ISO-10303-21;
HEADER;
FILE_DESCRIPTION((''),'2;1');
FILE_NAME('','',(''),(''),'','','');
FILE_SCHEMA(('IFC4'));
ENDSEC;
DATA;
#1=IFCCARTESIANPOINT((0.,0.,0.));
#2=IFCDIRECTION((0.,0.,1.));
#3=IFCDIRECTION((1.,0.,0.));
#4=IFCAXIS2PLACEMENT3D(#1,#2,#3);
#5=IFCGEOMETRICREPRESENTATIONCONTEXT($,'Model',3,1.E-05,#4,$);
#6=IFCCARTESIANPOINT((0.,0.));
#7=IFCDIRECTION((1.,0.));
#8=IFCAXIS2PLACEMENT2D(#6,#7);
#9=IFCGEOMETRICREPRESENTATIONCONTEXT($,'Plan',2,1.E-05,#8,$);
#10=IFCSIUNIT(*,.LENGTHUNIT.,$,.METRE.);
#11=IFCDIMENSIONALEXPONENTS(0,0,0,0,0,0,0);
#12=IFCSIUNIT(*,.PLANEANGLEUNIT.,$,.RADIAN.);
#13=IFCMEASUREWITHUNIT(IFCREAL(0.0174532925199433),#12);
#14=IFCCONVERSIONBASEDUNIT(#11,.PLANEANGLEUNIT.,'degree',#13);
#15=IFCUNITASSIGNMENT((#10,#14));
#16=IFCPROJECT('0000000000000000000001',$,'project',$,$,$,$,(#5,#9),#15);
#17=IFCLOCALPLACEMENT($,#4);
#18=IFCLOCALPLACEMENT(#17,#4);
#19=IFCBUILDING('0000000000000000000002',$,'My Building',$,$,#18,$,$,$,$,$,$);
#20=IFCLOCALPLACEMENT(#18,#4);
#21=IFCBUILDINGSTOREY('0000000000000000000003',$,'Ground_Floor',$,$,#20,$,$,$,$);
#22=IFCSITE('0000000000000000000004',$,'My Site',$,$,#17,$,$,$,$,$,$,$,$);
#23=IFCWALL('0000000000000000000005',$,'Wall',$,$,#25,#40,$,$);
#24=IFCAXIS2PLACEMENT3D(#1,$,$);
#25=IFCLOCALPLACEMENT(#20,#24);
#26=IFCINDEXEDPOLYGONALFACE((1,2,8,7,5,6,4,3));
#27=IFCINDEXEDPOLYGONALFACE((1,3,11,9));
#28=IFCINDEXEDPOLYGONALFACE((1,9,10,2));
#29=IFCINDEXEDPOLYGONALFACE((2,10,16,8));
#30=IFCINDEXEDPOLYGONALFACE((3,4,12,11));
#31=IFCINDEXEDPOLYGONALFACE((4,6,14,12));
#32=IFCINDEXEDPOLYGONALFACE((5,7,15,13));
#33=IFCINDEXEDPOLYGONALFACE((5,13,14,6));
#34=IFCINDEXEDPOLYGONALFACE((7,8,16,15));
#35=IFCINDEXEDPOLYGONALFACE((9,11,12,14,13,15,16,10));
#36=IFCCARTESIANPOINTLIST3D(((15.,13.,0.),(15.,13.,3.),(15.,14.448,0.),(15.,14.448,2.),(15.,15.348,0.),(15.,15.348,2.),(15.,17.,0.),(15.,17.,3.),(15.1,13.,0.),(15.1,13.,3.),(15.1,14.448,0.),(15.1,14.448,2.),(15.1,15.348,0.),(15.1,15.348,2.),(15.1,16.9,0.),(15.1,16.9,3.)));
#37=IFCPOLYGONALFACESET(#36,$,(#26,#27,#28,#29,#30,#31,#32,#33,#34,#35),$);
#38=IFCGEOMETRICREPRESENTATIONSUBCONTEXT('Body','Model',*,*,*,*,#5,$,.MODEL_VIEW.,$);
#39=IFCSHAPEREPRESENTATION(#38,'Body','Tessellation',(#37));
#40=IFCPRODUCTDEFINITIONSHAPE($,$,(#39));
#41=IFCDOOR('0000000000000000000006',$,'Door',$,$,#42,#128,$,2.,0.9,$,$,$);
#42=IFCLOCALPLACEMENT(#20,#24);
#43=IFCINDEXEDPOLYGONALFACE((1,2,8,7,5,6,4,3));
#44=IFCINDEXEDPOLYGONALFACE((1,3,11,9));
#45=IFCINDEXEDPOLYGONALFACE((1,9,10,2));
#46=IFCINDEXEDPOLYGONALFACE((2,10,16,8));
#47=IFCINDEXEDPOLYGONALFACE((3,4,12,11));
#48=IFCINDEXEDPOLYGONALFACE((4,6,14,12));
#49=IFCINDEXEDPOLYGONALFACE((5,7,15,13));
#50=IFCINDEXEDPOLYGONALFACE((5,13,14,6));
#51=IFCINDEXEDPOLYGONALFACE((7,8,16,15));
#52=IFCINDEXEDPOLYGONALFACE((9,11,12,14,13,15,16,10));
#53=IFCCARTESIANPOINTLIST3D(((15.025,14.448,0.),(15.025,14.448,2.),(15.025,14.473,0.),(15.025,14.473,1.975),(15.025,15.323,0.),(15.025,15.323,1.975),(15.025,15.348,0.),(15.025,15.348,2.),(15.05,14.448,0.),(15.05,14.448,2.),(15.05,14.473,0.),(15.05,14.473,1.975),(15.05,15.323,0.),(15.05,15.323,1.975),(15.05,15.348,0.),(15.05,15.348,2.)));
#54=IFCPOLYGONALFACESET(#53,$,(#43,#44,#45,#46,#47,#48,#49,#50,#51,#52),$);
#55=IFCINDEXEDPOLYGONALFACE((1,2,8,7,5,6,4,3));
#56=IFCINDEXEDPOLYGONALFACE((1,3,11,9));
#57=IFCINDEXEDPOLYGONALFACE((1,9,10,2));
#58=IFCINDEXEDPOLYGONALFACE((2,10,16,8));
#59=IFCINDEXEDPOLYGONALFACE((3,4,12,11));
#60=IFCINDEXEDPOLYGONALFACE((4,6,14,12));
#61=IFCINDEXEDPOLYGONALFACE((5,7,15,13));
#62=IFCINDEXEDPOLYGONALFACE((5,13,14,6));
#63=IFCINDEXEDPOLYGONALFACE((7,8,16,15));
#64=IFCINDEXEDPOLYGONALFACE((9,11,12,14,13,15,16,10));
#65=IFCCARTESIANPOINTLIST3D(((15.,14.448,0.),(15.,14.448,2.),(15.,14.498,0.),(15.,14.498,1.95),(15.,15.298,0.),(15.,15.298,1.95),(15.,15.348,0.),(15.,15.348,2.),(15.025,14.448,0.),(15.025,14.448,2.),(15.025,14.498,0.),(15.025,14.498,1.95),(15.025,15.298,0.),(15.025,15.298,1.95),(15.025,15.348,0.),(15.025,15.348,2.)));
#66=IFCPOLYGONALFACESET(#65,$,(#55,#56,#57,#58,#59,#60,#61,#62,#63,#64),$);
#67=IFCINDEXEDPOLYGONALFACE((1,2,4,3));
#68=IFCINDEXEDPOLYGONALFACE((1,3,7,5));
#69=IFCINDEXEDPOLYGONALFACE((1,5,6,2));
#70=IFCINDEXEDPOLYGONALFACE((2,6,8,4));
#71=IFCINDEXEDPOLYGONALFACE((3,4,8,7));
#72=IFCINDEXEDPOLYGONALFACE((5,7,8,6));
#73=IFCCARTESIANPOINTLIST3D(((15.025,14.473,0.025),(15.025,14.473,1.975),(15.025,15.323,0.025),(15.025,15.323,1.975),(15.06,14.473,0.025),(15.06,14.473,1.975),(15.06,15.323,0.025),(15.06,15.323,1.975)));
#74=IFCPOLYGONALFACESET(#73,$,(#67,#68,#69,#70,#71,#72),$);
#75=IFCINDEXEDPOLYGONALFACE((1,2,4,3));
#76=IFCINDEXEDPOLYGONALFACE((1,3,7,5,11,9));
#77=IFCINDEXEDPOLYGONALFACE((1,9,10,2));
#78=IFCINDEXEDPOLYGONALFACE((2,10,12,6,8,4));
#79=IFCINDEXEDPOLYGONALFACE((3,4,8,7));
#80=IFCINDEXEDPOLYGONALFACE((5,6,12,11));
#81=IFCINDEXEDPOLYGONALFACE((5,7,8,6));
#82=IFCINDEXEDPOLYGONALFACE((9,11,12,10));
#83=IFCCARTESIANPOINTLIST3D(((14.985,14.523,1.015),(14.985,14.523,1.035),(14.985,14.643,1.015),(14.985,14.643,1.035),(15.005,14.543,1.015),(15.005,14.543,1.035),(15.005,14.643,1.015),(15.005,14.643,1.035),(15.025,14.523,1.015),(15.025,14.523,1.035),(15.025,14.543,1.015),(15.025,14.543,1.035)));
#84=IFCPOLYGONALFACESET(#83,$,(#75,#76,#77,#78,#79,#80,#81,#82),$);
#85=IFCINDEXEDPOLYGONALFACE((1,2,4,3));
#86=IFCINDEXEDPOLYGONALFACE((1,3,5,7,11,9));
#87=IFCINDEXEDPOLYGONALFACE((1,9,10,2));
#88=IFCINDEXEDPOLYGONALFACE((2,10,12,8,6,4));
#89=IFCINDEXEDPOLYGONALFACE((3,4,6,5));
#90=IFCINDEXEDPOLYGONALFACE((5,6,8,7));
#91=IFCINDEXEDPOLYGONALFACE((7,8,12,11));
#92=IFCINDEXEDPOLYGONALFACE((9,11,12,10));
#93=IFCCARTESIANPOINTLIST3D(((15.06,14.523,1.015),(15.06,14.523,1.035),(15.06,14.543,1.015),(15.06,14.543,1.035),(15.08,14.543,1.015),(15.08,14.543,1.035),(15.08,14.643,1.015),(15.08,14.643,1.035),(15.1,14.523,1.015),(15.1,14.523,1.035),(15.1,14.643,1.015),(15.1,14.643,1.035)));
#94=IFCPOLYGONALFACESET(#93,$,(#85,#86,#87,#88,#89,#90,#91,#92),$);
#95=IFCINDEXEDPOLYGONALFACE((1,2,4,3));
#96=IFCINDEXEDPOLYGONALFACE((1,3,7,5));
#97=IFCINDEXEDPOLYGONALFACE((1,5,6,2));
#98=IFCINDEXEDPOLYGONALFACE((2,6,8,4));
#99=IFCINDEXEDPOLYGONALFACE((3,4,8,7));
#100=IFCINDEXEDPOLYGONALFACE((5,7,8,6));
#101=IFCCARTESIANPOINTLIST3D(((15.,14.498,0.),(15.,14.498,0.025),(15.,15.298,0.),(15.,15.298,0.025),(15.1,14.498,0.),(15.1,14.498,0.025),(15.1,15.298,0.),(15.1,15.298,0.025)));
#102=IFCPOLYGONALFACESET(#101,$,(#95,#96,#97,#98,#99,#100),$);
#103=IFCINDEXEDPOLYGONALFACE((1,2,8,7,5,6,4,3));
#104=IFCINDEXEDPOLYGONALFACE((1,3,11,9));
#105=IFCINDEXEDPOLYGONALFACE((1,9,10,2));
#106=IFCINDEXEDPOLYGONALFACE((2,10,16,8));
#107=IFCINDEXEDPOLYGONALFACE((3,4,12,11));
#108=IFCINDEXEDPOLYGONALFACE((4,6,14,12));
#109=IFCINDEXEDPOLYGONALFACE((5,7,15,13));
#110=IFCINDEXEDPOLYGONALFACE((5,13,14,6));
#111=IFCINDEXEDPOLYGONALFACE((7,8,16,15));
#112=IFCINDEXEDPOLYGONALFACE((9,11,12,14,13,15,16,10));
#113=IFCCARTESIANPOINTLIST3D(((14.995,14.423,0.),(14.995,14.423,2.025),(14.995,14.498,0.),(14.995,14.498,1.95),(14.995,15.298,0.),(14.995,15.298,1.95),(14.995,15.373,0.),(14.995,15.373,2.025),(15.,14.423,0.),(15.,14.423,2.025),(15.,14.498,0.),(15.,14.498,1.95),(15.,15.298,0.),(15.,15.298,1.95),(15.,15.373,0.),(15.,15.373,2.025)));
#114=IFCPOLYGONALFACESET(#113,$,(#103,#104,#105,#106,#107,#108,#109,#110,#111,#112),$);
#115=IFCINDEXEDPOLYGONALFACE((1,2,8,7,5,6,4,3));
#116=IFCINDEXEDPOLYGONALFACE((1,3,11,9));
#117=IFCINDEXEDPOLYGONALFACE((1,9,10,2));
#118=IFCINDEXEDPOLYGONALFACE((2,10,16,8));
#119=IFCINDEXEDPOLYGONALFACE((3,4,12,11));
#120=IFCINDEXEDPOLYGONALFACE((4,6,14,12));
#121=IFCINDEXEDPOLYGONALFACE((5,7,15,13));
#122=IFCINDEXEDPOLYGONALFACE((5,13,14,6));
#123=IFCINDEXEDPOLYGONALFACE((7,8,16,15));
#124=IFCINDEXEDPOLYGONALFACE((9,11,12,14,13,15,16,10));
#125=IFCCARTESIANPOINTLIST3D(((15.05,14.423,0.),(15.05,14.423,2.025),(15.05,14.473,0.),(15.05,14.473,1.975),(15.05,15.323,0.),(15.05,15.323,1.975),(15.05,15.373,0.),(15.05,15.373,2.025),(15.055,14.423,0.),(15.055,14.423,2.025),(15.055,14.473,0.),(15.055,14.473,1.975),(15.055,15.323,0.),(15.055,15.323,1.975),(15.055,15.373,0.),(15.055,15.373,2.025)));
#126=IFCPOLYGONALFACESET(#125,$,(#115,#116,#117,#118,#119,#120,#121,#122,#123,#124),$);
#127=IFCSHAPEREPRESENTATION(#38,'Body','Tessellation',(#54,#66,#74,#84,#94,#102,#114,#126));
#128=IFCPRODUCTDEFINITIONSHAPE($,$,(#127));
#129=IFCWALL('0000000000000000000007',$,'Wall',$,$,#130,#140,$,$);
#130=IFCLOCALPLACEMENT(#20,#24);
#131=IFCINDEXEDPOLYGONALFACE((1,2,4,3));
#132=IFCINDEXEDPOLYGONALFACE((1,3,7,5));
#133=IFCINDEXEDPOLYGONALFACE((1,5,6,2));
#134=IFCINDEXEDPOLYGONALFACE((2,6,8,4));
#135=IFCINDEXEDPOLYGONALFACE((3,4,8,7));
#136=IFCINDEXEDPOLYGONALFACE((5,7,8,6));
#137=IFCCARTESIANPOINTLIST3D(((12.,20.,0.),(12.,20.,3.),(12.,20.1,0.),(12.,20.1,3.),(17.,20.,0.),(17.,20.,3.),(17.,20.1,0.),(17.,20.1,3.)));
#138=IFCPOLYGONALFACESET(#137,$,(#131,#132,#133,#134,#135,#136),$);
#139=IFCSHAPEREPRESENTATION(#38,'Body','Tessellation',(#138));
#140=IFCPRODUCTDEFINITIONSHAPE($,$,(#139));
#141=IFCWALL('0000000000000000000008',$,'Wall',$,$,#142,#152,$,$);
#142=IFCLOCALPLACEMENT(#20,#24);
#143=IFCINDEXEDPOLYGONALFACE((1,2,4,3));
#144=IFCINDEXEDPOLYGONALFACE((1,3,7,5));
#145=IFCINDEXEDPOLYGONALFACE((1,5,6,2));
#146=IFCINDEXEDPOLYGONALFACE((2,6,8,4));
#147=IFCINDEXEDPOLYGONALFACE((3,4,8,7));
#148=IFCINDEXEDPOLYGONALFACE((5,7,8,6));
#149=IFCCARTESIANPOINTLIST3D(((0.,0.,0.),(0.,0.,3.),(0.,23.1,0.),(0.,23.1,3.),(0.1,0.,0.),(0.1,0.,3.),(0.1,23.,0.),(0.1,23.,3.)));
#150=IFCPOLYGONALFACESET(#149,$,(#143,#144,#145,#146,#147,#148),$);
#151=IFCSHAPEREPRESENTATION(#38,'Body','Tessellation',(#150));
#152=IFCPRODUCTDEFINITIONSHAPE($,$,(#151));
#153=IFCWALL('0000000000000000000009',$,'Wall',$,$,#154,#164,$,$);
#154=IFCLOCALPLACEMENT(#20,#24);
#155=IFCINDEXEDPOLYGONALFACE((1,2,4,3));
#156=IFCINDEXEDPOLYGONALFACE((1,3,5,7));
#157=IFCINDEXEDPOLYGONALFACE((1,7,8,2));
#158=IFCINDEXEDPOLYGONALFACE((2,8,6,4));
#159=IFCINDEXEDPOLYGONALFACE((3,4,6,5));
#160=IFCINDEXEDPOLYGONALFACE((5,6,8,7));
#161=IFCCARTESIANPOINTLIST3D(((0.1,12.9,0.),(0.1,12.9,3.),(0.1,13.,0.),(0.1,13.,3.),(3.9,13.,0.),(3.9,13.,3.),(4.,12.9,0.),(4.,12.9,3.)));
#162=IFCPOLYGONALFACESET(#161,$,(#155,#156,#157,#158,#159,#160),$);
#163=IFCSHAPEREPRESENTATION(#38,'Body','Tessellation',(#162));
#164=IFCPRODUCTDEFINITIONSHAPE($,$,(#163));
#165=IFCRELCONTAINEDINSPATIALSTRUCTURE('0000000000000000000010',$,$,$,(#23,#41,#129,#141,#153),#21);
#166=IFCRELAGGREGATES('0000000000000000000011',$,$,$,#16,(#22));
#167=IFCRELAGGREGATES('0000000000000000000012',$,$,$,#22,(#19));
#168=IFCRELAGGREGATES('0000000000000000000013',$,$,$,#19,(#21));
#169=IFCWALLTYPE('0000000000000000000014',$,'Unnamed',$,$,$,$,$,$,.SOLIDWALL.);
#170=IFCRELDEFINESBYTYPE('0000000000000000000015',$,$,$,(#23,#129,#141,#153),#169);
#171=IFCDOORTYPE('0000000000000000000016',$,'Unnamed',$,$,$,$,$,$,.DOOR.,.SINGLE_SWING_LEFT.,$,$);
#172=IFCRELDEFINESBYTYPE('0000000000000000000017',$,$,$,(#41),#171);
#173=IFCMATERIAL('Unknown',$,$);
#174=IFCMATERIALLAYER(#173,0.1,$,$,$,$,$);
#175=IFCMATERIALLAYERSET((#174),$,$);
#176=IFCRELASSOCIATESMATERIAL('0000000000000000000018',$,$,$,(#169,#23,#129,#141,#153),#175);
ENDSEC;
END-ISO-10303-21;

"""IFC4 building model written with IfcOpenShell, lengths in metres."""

from ifc_helpers import new_model, entity, si_unit, converted_unit, frame, origin_with_axes, origin_2d_with_axis, place, context, subcontext, project, spatial, line, indexed_curve, outline, extrude, shape, source, transform, mapped, material, layer, layer_set, layer_usage, type_object, type_shapes, element, fill, save


model = new_model("IFC4")

# Units and contexts
model_context = context("Model", 3, precision=1e-05, world=origin_with_axes())
plan_context = context("Plan", 2, precision=1e-05, world=origin_2d_with_axis())
body_context_1 = subcontext(model_context, "Body", "Model", "MODEL_VIEW")
body_context_2 = subcontext(plan_context, "Body", "Plan", "PLAN_VIEW")
ifc_project = project(units=[si_unit("LENGTHUNIT", "METRE"), converted_unit("PLANEANGLEUNIT", "degree", entity("IfcReal", 0.0174532925199433), si_unit("PLANEANGLEUNIT", "RADIAN"), dimensions=[0, 0, 0, 0, 0, 0, 0])], contexts=[model_context, plan_context])

# Site, building, storey
site_placement = place(None, origin_with_axes())
site = spatial("IfcSite", under=ifc_project, at=site_placement, Name="My Site")
building_placement = place(site_placement, origin_with_axes())
building = spatial("IfcBuilding", under=site, at=building_placement, Name="My Building")
storey_placement = place(building_placement, origin_with_axes())
storey = spatial("IfcBuildingStorey", under=building, at=storey_placement, Name="Ground_Floor")

# Shared definitions
ifc_material = material(Name="Unknown")

# Shared definitions
ifc_layer_1 = layer(ifc_material, 0.1)
ifc_layer_set_1 = layer_set([ifc_layer_1])
wall_type = type_object("IfcWallType", Name="Unnamed", PredefinedType="SOLIDWALL", material=ifc_layer_set_1)

# Shared definitions
shared_shape_1 = source(origin_with_axes(), body_context_1, "Body", "SweptSolid", [
    extrude(outline(indexed_curve([(0.0, 0.0), (0.9, 0.0), (0.9, 2.0), (0.0, 2.0)], segments=[line(1, 2, 3, 4, 1)])), frame((0.0, -0.6, 0.0), z_axis=(0.0, -1.0, 0.0), x_axis=(1.0, 0.0, 0.0)), (0.0, 0.0, -1.0), 1.2),
])
door_type_1 = type_object("IfcDoorType", Name="Unnamed", OperationType="SINGLE_SWING_LEFT", PredefinedType="DOOR")
shared_shape_2 = source(origin_with_axes(), body_context_1, "Body", "SweptSolid", [
    extrude(outline(indexed_curve([(0.0, 0.0), (0.0, 2.0), (0.9, 2.0), (0.9, 0.0), (0.875, 0.0), (0.875, 1.975), (0.025, 1.975), (0.025, 0.0)], segments=[line(1, 2, 3, 4, 5, 6, 7, 8, 1)])), frame((0.0, 0.025, 0.0), z_axis=(0.0, -1.0, 0.0), x_axis=(1.0, 0.0, 0.0)), (0.0, 0.0, -1.0), 0.025),
    extrude(outline(indexed_curve([(0.0, 0.0), (0.0, 2.0), (0.9, 2.0), (0.9, 0.0), (0.85, 0.0), (0.85, 1.95), (0.05, 1.95), (0.05, 0.0)], segments=[line(1, 2, 3, 4, 5, 6, 7, 8, 1)])), frame((0.0, 0.0, 0.0), z_axis=(0.0, -1.0, 0.0), x_axis=(1.0, 0.0, 0.0)), (0.0, 0.0, -1.0), 0.025),
    extrude(outline(indexed_curve([(0.0, 0.0), (0.85, 0.0), (0.85, 0.035), (0.0, 0.035)], segments=[line(1, 2, 3, 4, 1)])), frame((0.025, 0.025, 0.025), z_axis=(0.0, 0.0, 1.0), x_axis=(1.0, 0.0, 0.0)), (0.0, 0.0, 1.0), 1.95),
    extrude(outline(indexed_curve([(0.0, 0.0), (0.0, -0.04), (-0.12, -0.04), (-0.12, -0.02), (-0.02, -0.02), (-0.02, 0.0)], segments=[line(1, 2, 3, 4, 5, 6, 1)])), frame((0.825, 0.025, 1.015), z_axis=(0.0, 0.0, 1.0), x_axis=(1.0, 0.0, 0.0)), (0.0, 0.0, 1.0), 0.02),
    extrude(outline(indexed_curve([(0.0, 0.0), (0.0, 0.04), (-0.12, 0.04), (-0.12, 0.02), (-0.02, 0.02), (-0.02, 0.0)], segments=[line(1, 2, 3, 4, 5, 6, 1)])), frame((0.825, 0.06, 1.015), z_axis=(0.0, 0.0, 1.0), x_axis=(1.0, 0.0, 0.0)), (0.0, 0.0, 1.0), 0.02),
    extrude(outline(indexed_curve([(0.0, 0.0), (0.8, 0.0), (0.8, 0.1), (0.0, 0.1)], segments=[line(1, 2, 3, 4, 1)])), frame((0.05, 0.0, 0.0), z_axis=(0.0, 0.0, 1.0), x_axis=(1.0, 0.0, 0.0)), (0.0, 0.0, 1.0), 0.025),
    extrude(outline(indexed_curve([(0.0, 0.0), (0.0, 2.025), (0.95, 2.025), (0.95, 0.0), (0.875, 0.0), (0.875, 1.95), (0.075, 1.95), (0.075, 0.0)], segments=[line(1, 2, 3, 4, 5, 6, 7, 8, 1)])), frame((-0.025, -0.005, 0.0), z_axis=(0.0, -1.0, 0.0), x_axis=(1.0, 0.0, 0.0)), (0.0, 0.0, -1.0), 0.005),
    extrude(outline(indexed_curve([(0.0, 0.0), (0.0, 2.025), (0.95, 2.025), (0.95, 0.0), (0.9, 0.0), (0.9, 1.975), (0.05, 1.975), (0.05, 0.0)], segments=[line(1, 2, 3, 4, 5, 6, 7, 8, 1)])), frame((-0.025, 0.05, 0.0), z_axis=(0.0, -1.0, 0.0), x_axis=(1.0, 0.0, 0.0)), (0.0, 0.0, -1.0), 0.005),
])
shared_shape_3 = source(origin_with_axes(), body_context_2, "Body", "Curve2D", [
    entity("IfcIndexedPolyCurve", entity("IfcCartesianPointList2D", [[0.0, 0.0], [0.0, 0.05], [0.025, 0.05], [0.025, 0.025], [0.05, 0.025], [0.05, 0.0]]), [entity("IfcLineIndex", [1, 2, 3, 4, 5, 6, 1])]),
    entity("IfcIndexedPolyCurve", entity("IfcCartesianPointList2D", [[0.9, 0.0], [0.9, 0.05], [0.875, 0.05], [0.875, 0.025], [0.85, 0.025], [0.85, 0.0]]), [entity("IfcLineIndex", [1, 2, 3, 4, 5, 6, 1])]),
    entity("IfcTrimmedCurve", entity("IfcEllipse", entity("IfcAxis2Placement2D", entity("IfcCartesianPoint", [0.06, 0.05]), entity("IfcDirection", [1.0, 0.0])), 0.815, 0.85), [entity("IfcCartesianPoint", [0.875, 0.05])], [entity("IfcCartesianPoint", [0.06, 0.9])], True, "CARTESIAN"),
    entity("IfcIndexedPolyCurve", entity("IfcCartesianPointList2D", [[0.025, 0.05], [0.06, 0.05], [0.06, 0.9], [0.025, 0.9]]), [entity("IfcLineIndex", [1, 2, 3, 4, 1])]),
])
type_shapes(door_type_1, [shared_shape_2, shared_shape_3])

# Wall, opening, door
ifc_layer_usage_1 = layer_usage(ifc_layer_set_1, "AXIS2", "POSITIVE", 0.0)
wall_1_placement = place(storey_placement, frame((15.0, 17.0, 0.0), z_axis=(0.0, 0.0, 1.0), x_axis=(0.0, -1.0, 0.0)))
wall_1 = element("IfcWall", 1, at=wall_1_placement, inside=storey, type_object=wall_type, material=ifc_layer_usage_1, Name="Wall", context=body_context_1, shape_type="SweptSolid", body=[
    extrude(outline(indexed_curve([(0.0, 0.0), (0.1, 0.1), (4.0, 0.1), (4.0, 0.0)], segments=[line(1, 2, 3, 4, 1)])), origin_with_axes(), (0.0, 0.0, 1.0), 3.0),
])
opening_1_placement = place(wall_1_placement, frame((1.652, 0.0, 0.0), z_axis=(0.0, 0.0, 1.0), x_axis=(1.0, 0.0, 0.0)))
opening_1 = element("IfcOpeningElement", 2, at=opening_1_placement, cuts=wall_1, PredefinedType="OPENING", context=body_context_1, shape_type="MappedRepresentation", body=[
    mapped(shared_shape_1, transform((0.0, 0.0, 0.0), x_axis=(1.0, 0.0, 0.0), y_axis=(0.0, 1.0, 0.0), z_axis=(0.0, 0.0, 1.0), scale=1.0)),
])
door_1_placement = place(opening_1_placement, frame((0.0, 0.0, 0.0), z_axis=(0.0, 0.0, 1.0), x_axis=(1.0, 0.0, 0.0)))
door_1 = element("IfcDoor", 3, at=door_1_placement, inside=storey, type_object=door_type_1, Name="Door", OverallHeight=2.0, OverallWidth=0.9, shapes=[
    shape(body_context_1, "Body", "MappedRepresentation", [mapped(shared_shape_2, transform((0.0, 0.0, 0.0), x_axis=(1.0, 0.0, 0.0), y_axis=(0.0, 1.0, 0.0), z_axis=(0.0, 0.0, 1.0), scale=1.0))]),
    shape(body_context_2, "Body", "MappedRepresentation", [mapped(shared_shape_3, transform((0.0, 0.0, 0.0), x_axis=(1.0, 0.0, 0.0), y_axis=(0.0, 1.0, 0.0), z_axis=(0.0, 0.0, 1.0), scale=1.0))]),
])
fill(opening_1, door_1)

# Walls
ifc_layer_usage_2 = layer_usage(ifc_layer_set_1, "AXIS2", "POSITIVE", 0.0)
wall_2_placement = place(storey_placement, frame((12.0, 20.0, 0.0), z_axis=(0.0, 0.0, 1.0), x_axis=(1.0, 0.0, 0.0)))
element("IfcWall", 4, at=wall_2_placement, inside=storey, type_object=wall_type, material=ifc_layer_usage_2, Name="Wall", context=body_context_1, shape_type="SweptSolid", body=[
    extrude(outline(indexed_curve([(0.0, 0.0), (0.0, 0.1), (5.0, 0.1), (5.0, 0.0)], segments=[line(1, 2, 3, 4, 1)])), origin_with_axes(), (0.0, 0.0, 1.0), 3.0),
])
ifc_layer_usage_3 = layer_usage(ifc_layer_set_1, "AXIS2", "POSITIVE", 0.0)
wall_3_placement = place(storey_placement, frame((0.0, 23.0, 0.0), z_axis=(0.0, 0.0, 1.0), x_axis=(0.0, -1.0, 0.0)))
element("IfcWall", 5, at=wall_3_placement, inside=storey, type_object=wall_type, material=ifc_layer_usage_3, Name="Wall", context=body_context_1, shape_type="SweptSolid", body=[
    extrude(outline(indexed_curve([(-0.1, 0.0), (0.0, 0.1), (23.0, 0.1), (23.0, 0.0)], segments=[line(1, 2, 3, 4, 1)])), origin_with_axes(), (0.0, 0.0, 1.0), 3.0),
])

# Wall
ifc_layer_usage_4 = layer_usage(ifc_layer_set_1, "AXIS2", "POSITIVE", 0.0)
wall_4_placement = place(storey_placement, frame((4.0, 13.0, 0.0), z_axis=(0.0, 0.0, 1.0), x_axis=(-1.0, 0.0, 0.0)))
element("IfcWall", 6, at=wall_4_placement, inside=storey, type_object=wall_type, material=ifc_layer_usage_4, Name="Wall", context=body_context_1, shape_type="SweptSolid", body=[
    extrude(outline(indexed_curve([(0.1, 0.0), (0.0, 0.1), (3.9, 0.1), (3.9, 0.0)], segments=[line(1, 2, 3, 4, 1)])), origin_with_axes(), (0.0, 0.0, 1.0), 3.0),
])

save(model, "model.ifc")
